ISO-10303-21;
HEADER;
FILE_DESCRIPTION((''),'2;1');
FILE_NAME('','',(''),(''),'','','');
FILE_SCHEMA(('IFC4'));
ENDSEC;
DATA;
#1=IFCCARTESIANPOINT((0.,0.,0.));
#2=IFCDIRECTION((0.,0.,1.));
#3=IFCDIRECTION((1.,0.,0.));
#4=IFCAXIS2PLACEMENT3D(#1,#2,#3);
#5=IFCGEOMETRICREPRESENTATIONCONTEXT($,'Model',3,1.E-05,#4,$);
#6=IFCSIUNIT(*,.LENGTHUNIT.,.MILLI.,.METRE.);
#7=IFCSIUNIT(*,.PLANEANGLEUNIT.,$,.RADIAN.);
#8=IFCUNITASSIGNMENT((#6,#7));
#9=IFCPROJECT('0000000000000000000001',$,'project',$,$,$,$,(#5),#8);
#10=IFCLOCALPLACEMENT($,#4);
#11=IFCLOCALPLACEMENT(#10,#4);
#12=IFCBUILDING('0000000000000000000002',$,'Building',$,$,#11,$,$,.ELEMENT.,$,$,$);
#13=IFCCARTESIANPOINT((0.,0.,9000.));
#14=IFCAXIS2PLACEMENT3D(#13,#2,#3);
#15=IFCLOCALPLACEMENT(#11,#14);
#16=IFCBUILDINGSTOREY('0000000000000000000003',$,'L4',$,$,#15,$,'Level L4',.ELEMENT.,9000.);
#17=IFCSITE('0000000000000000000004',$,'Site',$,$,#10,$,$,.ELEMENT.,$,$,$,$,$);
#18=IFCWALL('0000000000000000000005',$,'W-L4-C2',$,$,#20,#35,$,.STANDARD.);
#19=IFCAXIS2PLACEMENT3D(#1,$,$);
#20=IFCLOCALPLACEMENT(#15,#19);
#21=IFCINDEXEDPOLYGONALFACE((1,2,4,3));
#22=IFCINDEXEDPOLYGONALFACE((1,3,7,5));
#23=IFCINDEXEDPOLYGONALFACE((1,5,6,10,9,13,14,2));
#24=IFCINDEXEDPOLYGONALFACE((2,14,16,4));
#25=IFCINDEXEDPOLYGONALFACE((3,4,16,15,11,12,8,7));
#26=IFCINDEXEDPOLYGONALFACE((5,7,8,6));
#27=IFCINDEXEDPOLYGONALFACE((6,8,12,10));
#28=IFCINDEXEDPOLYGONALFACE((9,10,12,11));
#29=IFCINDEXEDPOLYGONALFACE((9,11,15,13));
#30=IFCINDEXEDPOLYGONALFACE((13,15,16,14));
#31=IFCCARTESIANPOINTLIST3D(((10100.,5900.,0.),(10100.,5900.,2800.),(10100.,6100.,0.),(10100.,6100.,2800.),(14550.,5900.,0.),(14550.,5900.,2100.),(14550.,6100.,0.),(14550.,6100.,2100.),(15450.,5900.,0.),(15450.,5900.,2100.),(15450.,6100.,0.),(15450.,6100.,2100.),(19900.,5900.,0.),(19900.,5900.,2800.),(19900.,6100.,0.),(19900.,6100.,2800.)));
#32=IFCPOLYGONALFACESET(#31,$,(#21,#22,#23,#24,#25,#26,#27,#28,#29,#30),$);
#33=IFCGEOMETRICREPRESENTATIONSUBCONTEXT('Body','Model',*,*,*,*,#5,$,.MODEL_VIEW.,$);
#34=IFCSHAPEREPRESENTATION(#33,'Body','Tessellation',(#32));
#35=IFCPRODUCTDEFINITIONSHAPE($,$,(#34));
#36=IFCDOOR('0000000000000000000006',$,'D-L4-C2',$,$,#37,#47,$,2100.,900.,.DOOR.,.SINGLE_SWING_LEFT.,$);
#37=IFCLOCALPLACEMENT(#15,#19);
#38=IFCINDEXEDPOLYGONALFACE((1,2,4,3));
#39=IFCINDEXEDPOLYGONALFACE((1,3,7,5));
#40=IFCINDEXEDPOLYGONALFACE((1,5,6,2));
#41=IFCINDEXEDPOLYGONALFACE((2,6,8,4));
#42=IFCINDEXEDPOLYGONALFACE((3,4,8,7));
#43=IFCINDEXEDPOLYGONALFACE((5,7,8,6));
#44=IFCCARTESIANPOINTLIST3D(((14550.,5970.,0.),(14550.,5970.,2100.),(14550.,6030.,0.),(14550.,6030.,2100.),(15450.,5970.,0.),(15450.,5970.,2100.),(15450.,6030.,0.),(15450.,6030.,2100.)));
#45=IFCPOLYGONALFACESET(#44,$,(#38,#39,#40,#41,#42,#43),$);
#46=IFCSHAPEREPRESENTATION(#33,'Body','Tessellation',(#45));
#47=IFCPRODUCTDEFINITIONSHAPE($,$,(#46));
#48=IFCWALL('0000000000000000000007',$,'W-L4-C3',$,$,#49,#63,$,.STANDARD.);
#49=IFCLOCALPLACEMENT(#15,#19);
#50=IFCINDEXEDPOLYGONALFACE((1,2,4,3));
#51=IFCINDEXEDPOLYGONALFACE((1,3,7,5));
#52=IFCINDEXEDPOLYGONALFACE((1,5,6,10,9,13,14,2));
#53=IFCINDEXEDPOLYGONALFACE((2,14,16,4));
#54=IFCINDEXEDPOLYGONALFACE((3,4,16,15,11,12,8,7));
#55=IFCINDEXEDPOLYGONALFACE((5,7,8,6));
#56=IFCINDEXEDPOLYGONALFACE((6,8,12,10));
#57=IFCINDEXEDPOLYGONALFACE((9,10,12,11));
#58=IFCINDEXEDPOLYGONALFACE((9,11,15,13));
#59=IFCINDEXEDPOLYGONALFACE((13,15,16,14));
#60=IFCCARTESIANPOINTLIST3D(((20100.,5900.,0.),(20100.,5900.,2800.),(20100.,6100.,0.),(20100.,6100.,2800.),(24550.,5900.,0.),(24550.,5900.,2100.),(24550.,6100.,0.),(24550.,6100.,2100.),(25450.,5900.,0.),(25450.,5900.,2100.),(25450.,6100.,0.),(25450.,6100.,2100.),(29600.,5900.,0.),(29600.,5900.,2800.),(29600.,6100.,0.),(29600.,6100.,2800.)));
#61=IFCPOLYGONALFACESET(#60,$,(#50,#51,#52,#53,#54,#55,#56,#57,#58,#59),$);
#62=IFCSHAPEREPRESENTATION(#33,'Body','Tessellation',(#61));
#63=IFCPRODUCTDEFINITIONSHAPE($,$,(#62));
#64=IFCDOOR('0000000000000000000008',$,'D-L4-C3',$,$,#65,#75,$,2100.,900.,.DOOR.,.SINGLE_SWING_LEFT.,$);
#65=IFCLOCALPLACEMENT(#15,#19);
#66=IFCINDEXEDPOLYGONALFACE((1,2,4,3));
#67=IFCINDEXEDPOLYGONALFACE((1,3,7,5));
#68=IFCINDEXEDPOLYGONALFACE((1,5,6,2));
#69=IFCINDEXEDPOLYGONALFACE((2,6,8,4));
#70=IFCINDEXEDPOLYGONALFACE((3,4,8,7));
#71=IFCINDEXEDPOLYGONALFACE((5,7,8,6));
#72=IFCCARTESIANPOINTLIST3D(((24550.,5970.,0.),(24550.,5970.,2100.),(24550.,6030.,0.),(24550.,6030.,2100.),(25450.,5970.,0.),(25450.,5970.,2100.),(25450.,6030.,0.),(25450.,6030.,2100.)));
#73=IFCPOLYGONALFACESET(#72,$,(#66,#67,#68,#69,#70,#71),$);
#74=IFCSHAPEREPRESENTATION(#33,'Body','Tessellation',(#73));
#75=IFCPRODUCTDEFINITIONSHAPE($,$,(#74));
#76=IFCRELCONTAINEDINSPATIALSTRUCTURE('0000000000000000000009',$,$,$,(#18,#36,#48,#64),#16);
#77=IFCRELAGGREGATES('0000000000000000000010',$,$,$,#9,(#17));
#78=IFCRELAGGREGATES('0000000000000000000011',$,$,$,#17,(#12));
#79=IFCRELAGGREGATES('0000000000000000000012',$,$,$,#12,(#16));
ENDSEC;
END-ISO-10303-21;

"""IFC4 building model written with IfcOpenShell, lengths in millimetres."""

from ifc_helpers import new_model, si_unit, frame, origin_with_axes, origin_2d, place, context, subcontext, project, spatial, rectangle, extrude, element, fill, save


model = new_model("IFC4")

# Units and contexts
model_context = context("Model", 3, precision=1e-05, world=origin_with_axes())
body_context = subcontext(model_context, "Body", "Model", "MODEL_VIEW")
ifc_project = project(units=[si_unit("LENGTHUNIT", "METRE", prefix="MILLI"), si_unit("PLANEANGLEUNIT", "RADIAN")], contexts=[model_context])

# Site, building, storey
site_placement = place(None, origin_with_axes())
site = spatial("IfcSite", under=ifc_project, at=site_placement, Name="Site", CompositionType="ELEMENT")
building_placement = place(site_placement, origin_with_axes())
building = spatial("IfcBuilding", under=site, at=building_placement, Name="Building", CompositionType="ELEMENT")
storey_placement = place(building_placement, frame((0.0, 0.0, 9000.0), z_axis=(0.0, 0.0, 1.0), x_axis=(1.0, 0.0, 0.0)))
storey = spatial("IfcBuildingStorey", under=building, at=storey_placement, Name="L4", LongName="Level L4", CompositionType="ELEMENT", Elevation=9000.0)

# Walls, openings, doors
wall_1_placement = place(storey_placement, frame((15000.0, 6000.0, 0.0), z_axis=(0.0, 0.0, 1.0), x_axis=(1.0, 0.0, 0.0)))
wall_1 = element("IfcWall", 1, at=wall_1_placement, inside=storey, Name="W-L4-C2", PredefinedType="STANDARD", context=body_context, shape_type="SweptSolid", body=[
    extrude(rectangle(XDim=9800.0, YDim=200.0, at=origin_2d()), origin_with_axes(), (0.0, 0.0, 1.0), 2800.0),
])
opening_1_placement = place(wall_1_placement, origin_with_axes())
opening_1 = element("IfcOpeningElement", 2, at=opening_1_placement, cuts=wall_1, PredefinedType="OPENING", context=body_context, shape_type="SweptSolid", body=[
    extrude(rectangle(XDim=900.0, YDim=300.0, at=origin_2d()), origin_with_axes(), (0.0, 0.0, 1.0), 2100.0),
])
door_1_placement = place(wall_1_placement, origin_with_axes())
door_1 = element("IfcDoor", 3, at=door_1_placement, inside=storey, Name="D-L4-C2", OperationType="SINGLE_SWING_LEFT", OverallHeight=2100.0, OverallWidth=900.0, PredefinedType="DOOR", context=body_context, shape_type="SweptSolid", body=[
    extrude(rectangle(XDim=900.0, YDim=60.0, at=origin_2d()), origin_with_axes(), (0.0, 0.0, 1.0), 2100.0),
])
fill(opening_1, door_1)
wall_2_placement = place(storey_placement, frame((24850.0, 6000.0, 0.0), z_axis=(0.0, 0.0, 1.0), x_axis=(1.0, 0.0, 0.0)))
wall_2 = element("IfcWall", 4, at=wall_2_placement, inside=storey, Name="W-L4-C3", PredefinedType="STANDARD", context=body_context, shape_type="SweptSolid", body=[
    extrude(rectangle(XDim=9500.0, YDim=200.0, at=origin_2d()), origin_with_axes(), (0.0, 0.0, 1.0), 2800.0),
])
opening_2_placement = place(wall_2_placement, frame((150.0, 0.0, 0.0), z_axis=(0.0, 0.0, 1.0), x_axis=(1.0, 0.0, 0.0)))
opening_2 = element("IfcOpeningElement", 5, at=opening_2_placement, cuts=wall_2, PredefinedType="OPENING", context=body_context, shape_type="SweptSolid", body=[
    extrude(rectangle(XDim=900.0, YDim=300.0, at=origin_2d()), origin_with_axes(), (0.0, 0.0, 1.0), 2100.0),
])
door_2_placement = place(wall_2_placement, frame((150.0, 0.0, 0.0), z_axis=(0.0, 0.0, 1.0), x_axis=(1.0, 0.0, 0.0)))
door_2 = element("IfcDoor", 6, at=door_2_placement, inside=storey, Name="D-L4-C3", OperationType="SINGLE_SWING_LEFT", OverallHeight=2100.0, OverallWidth=900.0, PredefinedType="DOOR", context=body_context, shape_type="SweptSolid", body=[
    extrude(rectangle(XDim=900.0, YDim=60.0, at=origin_2d()), origin_with_axes(), (0.0, 0.0, 1.0), 2100.0),
])
fill(opening_2, door_2)

save(model, "model.ifc")
